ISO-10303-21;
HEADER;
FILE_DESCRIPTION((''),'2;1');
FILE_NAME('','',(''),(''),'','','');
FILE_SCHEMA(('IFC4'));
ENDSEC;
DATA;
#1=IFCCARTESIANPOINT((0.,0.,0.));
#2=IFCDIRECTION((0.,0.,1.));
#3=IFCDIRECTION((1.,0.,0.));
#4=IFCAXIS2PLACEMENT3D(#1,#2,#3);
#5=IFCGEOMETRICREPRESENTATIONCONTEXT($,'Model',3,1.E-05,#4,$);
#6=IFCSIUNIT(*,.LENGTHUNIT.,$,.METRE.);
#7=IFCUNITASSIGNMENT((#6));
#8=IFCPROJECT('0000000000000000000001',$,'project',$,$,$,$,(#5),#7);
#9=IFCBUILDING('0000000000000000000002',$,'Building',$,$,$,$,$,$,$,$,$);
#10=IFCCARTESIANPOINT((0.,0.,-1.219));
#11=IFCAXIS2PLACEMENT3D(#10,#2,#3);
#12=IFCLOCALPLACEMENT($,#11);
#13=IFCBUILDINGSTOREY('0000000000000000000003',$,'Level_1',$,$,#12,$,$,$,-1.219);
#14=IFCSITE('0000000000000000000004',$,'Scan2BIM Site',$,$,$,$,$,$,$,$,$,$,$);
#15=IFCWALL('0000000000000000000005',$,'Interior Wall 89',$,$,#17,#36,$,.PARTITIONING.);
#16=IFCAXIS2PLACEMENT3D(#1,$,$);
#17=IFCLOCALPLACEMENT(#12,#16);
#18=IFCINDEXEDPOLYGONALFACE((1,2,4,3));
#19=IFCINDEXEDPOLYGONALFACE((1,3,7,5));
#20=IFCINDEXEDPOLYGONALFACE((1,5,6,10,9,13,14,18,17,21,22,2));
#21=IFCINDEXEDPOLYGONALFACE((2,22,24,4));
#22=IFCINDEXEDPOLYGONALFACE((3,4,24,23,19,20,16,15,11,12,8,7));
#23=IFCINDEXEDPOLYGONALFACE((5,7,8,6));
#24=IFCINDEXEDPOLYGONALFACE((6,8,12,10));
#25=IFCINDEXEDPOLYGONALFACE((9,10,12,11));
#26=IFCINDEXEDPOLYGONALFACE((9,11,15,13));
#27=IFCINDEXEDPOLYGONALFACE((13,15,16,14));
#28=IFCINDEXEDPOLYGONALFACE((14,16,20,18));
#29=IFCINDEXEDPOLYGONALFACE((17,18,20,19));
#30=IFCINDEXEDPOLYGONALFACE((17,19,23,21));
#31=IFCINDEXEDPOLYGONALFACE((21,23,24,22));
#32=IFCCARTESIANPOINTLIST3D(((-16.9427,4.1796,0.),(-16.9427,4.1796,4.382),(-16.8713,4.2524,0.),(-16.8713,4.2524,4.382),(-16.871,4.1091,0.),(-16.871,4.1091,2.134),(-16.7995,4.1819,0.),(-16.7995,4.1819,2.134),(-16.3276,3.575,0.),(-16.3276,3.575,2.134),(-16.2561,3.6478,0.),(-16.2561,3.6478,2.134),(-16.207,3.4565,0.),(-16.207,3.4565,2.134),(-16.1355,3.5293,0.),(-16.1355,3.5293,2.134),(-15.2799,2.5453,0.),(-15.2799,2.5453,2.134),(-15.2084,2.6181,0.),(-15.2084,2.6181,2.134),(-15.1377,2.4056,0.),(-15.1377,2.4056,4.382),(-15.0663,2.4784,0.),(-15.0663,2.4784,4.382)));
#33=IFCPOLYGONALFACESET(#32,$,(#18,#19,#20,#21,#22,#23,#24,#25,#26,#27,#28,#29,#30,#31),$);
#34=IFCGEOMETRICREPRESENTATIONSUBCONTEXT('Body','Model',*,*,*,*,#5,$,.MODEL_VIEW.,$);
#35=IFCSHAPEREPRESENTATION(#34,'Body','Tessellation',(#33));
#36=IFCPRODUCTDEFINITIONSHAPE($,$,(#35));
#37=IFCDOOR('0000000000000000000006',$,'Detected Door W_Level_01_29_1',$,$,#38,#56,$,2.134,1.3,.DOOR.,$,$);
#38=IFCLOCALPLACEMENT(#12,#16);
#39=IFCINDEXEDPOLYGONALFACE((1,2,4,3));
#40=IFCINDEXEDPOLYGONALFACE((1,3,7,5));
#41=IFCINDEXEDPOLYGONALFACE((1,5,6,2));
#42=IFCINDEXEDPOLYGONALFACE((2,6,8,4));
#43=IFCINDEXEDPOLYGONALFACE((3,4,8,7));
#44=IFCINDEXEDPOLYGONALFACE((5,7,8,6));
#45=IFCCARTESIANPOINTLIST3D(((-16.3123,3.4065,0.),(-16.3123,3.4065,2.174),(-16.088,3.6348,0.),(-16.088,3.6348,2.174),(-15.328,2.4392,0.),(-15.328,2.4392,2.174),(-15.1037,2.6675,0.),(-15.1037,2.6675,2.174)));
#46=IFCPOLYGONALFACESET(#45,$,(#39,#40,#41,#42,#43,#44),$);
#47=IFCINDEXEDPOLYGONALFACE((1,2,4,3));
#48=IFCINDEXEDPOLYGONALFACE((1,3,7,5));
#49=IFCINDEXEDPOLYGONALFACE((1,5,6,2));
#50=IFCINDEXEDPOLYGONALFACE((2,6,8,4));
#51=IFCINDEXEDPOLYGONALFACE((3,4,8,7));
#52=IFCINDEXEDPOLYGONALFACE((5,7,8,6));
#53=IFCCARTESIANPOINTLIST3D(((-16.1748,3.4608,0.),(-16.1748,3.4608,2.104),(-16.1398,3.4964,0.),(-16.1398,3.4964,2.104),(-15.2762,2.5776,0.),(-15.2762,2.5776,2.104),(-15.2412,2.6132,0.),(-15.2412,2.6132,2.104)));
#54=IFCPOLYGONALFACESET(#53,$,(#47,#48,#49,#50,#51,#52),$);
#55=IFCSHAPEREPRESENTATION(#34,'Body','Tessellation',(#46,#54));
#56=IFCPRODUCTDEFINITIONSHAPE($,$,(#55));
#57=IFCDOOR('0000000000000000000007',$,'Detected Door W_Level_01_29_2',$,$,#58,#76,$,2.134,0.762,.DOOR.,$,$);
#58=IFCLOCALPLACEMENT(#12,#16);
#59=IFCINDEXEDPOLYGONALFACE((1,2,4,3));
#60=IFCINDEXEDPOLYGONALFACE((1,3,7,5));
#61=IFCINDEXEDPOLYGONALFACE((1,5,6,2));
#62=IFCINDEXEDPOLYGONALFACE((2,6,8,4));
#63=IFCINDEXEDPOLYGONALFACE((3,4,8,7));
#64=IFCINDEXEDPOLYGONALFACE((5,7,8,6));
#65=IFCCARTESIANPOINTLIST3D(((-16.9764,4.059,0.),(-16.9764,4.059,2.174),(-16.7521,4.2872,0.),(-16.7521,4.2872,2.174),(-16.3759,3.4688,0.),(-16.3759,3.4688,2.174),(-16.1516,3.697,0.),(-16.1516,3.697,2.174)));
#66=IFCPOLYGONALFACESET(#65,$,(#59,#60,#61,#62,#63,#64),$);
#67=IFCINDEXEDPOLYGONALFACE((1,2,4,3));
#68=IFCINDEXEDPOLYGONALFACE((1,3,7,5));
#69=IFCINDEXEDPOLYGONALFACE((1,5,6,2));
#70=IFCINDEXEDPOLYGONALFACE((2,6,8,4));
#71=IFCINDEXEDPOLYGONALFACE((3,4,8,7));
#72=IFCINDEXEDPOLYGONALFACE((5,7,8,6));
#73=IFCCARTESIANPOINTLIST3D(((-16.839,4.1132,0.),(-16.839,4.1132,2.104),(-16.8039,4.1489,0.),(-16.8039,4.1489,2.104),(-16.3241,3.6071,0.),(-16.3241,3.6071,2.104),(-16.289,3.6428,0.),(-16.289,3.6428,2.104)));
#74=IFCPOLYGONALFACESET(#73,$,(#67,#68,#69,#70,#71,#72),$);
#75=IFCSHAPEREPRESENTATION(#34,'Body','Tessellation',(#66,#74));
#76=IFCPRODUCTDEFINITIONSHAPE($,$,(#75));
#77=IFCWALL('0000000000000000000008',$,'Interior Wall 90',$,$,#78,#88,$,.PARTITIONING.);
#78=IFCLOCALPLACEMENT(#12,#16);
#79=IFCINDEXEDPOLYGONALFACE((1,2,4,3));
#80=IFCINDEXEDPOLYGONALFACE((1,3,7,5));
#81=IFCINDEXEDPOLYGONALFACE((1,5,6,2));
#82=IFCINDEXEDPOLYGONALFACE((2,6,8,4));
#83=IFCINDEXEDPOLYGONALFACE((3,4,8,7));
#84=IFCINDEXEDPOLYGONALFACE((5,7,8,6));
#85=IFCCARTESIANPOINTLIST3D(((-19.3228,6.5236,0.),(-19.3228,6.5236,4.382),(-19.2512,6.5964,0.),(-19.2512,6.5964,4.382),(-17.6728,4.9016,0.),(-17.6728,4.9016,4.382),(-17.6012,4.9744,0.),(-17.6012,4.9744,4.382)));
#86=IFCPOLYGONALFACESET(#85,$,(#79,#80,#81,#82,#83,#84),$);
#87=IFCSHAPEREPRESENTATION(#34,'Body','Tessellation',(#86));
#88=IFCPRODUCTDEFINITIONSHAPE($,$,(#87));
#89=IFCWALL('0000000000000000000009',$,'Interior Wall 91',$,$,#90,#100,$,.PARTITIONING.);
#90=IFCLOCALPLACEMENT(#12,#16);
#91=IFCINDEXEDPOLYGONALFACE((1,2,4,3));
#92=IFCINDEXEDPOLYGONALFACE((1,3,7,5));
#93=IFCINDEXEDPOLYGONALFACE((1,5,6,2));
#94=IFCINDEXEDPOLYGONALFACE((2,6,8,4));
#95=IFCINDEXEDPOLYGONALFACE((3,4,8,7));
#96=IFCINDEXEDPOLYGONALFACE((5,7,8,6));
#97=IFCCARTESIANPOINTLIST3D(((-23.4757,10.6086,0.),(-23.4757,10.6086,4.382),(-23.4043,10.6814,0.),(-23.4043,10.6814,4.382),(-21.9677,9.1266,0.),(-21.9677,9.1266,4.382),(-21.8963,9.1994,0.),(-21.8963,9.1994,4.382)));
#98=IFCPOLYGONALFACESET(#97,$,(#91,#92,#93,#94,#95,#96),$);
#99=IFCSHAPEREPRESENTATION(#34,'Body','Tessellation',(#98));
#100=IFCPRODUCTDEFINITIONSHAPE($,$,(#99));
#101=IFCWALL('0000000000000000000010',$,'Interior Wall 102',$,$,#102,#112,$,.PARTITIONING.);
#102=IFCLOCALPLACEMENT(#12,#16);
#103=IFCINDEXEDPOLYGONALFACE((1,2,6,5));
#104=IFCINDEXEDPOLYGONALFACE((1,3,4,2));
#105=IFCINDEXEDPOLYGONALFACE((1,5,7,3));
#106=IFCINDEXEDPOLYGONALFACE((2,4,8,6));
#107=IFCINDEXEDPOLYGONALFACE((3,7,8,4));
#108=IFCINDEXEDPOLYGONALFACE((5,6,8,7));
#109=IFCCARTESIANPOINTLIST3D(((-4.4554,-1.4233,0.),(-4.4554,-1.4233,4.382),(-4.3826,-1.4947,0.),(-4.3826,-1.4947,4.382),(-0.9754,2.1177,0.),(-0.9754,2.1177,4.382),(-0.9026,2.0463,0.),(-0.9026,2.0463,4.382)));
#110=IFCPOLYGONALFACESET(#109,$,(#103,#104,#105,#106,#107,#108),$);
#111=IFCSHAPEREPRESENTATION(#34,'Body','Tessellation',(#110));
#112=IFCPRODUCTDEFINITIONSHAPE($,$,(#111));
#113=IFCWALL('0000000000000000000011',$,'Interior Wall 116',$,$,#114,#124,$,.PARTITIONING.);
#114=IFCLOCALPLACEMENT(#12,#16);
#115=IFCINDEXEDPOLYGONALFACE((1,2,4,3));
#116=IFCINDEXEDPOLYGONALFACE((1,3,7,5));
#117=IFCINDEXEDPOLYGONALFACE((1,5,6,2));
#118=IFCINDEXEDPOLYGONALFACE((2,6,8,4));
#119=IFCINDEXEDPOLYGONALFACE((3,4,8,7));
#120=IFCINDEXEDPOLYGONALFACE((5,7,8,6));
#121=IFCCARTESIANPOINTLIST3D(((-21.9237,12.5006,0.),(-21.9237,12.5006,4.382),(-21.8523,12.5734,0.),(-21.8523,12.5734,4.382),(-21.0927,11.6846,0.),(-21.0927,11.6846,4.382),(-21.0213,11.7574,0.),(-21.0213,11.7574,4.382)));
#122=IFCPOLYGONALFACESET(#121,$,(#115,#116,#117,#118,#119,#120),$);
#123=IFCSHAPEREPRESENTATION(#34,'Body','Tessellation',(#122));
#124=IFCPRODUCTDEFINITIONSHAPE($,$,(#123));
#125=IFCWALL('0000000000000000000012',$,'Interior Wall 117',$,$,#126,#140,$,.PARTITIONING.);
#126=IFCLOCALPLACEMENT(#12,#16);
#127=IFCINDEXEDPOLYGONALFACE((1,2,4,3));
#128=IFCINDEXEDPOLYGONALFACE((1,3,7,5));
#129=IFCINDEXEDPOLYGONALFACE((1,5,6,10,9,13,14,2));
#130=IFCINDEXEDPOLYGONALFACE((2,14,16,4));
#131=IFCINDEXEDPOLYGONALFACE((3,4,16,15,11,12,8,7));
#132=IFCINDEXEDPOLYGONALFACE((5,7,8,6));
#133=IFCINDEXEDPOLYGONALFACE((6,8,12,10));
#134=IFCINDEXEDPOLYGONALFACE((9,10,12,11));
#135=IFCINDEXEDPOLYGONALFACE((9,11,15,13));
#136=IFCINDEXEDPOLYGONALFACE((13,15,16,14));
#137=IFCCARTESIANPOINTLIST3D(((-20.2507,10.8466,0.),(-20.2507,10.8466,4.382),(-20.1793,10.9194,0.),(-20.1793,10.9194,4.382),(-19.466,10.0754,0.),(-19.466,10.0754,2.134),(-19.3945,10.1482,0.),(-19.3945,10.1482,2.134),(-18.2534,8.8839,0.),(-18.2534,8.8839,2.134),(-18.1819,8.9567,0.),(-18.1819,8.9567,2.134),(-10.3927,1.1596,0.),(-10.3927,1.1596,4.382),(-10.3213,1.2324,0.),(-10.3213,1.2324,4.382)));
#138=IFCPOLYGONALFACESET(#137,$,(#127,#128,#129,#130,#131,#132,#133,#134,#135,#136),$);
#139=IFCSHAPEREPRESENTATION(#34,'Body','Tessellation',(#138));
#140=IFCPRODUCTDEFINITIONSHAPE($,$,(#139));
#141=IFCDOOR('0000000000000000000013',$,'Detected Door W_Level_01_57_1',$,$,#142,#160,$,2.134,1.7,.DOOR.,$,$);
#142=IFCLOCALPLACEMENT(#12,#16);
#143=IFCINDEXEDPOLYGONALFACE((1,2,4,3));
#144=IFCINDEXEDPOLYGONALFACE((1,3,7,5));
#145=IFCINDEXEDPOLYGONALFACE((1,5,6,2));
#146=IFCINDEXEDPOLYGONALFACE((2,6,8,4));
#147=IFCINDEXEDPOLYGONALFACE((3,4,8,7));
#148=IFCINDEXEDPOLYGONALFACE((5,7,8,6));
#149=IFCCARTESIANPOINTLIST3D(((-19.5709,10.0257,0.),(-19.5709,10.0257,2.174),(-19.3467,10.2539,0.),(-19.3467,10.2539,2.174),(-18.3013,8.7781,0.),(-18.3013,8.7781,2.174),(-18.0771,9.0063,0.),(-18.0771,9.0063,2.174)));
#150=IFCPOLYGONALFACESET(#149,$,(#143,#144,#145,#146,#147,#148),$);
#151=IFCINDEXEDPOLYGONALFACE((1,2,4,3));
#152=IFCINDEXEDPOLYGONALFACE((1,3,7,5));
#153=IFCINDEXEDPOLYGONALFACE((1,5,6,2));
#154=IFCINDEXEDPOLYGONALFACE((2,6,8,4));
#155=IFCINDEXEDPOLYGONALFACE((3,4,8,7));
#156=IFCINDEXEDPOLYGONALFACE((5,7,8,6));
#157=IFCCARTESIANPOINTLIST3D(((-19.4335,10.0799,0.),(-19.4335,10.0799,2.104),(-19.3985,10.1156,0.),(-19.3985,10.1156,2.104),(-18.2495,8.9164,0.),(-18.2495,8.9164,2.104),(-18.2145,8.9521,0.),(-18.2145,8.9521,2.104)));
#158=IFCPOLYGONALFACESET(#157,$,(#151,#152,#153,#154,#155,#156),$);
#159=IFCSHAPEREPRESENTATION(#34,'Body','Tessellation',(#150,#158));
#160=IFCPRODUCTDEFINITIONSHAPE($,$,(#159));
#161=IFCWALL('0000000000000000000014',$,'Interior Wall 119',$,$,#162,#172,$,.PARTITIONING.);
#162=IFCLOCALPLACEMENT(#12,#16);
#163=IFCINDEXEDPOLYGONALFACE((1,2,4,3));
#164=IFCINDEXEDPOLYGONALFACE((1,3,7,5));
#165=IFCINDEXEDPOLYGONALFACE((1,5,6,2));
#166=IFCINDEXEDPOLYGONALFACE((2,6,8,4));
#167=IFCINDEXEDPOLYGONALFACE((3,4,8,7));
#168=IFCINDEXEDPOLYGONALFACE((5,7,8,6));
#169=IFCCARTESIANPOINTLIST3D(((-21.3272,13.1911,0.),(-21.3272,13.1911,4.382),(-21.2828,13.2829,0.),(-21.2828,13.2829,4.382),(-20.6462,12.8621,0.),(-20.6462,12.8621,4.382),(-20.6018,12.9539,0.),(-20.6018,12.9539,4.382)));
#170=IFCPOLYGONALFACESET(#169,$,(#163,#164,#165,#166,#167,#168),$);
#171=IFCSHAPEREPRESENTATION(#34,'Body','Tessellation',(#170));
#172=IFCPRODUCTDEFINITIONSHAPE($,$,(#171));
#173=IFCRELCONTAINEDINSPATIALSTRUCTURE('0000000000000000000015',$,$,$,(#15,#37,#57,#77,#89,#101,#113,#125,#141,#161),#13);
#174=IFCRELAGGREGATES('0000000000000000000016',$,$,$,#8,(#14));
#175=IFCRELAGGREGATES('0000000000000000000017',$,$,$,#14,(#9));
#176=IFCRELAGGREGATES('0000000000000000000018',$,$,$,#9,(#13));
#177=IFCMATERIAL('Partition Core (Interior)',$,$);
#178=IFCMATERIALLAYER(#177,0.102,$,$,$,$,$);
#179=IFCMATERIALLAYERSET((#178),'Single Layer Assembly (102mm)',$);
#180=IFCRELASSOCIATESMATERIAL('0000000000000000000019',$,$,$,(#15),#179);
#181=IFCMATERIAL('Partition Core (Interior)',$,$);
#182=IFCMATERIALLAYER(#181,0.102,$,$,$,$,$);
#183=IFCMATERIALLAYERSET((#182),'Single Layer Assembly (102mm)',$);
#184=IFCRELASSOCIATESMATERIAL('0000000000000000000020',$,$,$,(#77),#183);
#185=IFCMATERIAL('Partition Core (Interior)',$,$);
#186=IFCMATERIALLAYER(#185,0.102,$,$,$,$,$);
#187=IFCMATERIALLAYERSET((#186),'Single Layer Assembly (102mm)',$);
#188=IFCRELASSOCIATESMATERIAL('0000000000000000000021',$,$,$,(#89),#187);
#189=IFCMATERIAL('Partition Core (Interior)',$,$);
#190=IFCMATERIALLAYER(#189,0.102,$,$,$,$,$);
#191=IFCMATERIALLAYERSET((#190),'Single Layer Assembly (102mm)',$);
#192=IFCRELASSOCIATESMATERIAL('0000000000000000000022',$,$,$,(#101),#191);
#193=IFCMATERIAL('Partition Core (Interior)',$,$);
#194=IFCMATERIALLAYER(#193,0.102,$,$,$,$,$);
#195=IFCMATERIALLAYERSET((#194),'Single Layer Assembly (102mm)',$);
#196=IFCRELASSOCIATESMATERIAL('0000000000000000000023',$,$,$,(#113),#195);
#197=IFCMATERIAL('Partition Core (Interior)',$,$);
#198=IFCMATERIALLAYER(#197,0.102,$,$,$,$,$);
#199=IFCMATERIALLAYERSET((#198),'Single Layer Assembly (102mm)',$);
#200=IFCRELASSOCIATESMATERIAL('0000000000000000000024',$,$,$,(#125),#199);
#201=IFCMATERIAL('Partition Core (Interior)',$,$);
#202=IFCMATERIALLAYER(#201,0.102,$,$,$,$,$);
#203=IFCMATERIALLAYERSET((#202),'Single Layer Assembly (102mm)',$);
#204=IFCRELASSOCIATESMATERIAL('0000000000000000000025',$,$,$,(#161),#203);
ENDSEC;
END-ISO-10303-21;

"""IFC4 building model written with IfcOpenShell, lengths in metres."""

from ifc_helpers import new_model, si_unit, frame, origin, origin_with_axes, place, context, subcontext, project, spatial, rectangle, extrude, material, layer, layer_set, element, fill, save


model = new_model("IFC4")

# Units and contexts
model_context = context("Model", 3, precision=1e-05, world=origin_with_axes())
body_context = subcontext(model_context, "Body", "Model", "MODEL_VIEW")
ifc_project = project(units=[si_unit("LENGTHUNIT", "METRE")], contexts=[model_context])

# Site, building, storey
site = spatial("IfcSite", under=ifc_project, Name="Scan2BIM Site")
building = spatial("IfcBuilding", under=site, Name="Building")
storey_placement = place(None, frame((0.0, 0.0, -1.219), z_axis=(0.0, 0.0, 1.0), x_axis=(1.0, 0.0, 0.0)))
storey = spatial("IfcBuildingStorey", under=building, at=storey_placement, Name="Level_1", Elevation=-1.219)

# Wall, openings, doors
ifc_material_1 = material(Name="Partition Core (Interior)")
ifc_layer_1 = layer(ifc_material_1, 0.102)
ifc_layer_set_1 = layer_set([ifc_layer_1], Name="Single Layer Assembly (102mm)")
wall_1_placement = place(storey_placement, frame((-16.0045, 3.329, 0.0), z_axis=(0.0, 0.0, 1.0), x_axis=(-0.713205, 0.700956, 0.0)))
wall_1 = element("IfcWall", 1, at=wall_1_placement, inside=storey, material=ifc_layer_set_1, Name="Interior Wall 89", PredefinedType="PARTITIONING", context=body_context, shape_type="SweptSolid", body=[
    extrude(rectangle(XDim=2.5308, YDim=0.102), origin(), (0.0, 0.0, 1.0), 4.382),
])
opening_1_placement = place(None, frame((-15.708, 3.037, -1.219), z_axis=(0.0, 0.0, 1.0), x_axis=(-0.713205, 0.700956, 0.0)))
opening_1 = element("IfcOpeningElement", 2, at=opening_1_placement, cuts=wall_1, PredefinedType="OPENING", context=body_context, shape_type="SweptSolid", body=[
    extrude(rectangle(XDim=1.3, YDim=0.202), origin(), (0.0, 0.0, 1.0), 2.134),
])
opening_2_placement = place(None, frame((-16.564, 3.878, -1.219), z_axis=(0.0, 0.0, 1.0), x_axis=(-0.713205, 0.700956, 0.0)))
opening_2 = element("IfcOpeningElement", 3, at=opening_2_placement, cuts=wall_1, PredefinedType="OPENING", context=body_context, shape_type="SweptSolid", body=[
    extrude(rectangle(XDim=0.762, YDim=0.202), origin(), (0.0, 0.0, 1.0), 2.134),
])
door_1_placement = place(opening_1_placement, frame((0.0, 0.0, 0.0), z_axis=(0.0, 0.0, 1.0), x_axis=(1.0, 0.0, 0.0)))
door_1 = element("IfcDoor", 4, at=door_1_placement, inside=storey, Name="Detected Door W_Level_01_29_1", OverallHeight=2.134, OverallWidth=1.3, PredefinedType="DOOR", context=body_context, shape_type="SweptSolid", body=[
    extrude(rectangle(XDim=1.38, YDim=0.32), origin(), (0.0, 0.0, 1.0), 2.174),
    extrude(rectangle(XDim=1.26, YDim=0.05), origin(), (0.0, 0.0, 1.0), 2.104),
])
fill(opening_1, door_1)
door_2_placement = place(opening_2_placement, frame((0.0, 0.0, 0.0), z_axis=(0.0, 0.0, 1.0), x_axis=(1.0, 0.0, 0.0)))
door_2 = element("IfcDoor", 5, at=door_2_placement, inside=storey, Name="Detected Door W_Level_01_29_2", OverallHeight=2.134, OverallWidth=0.762, PredefinedType="DOOR", context=body_context, shape_type="SweptSolid", body=[
    extrude(rectangle(XDim=0.842, YDim=0.32), origin(), (0.0, 0.0, 1.0), 2.174),
    extrude(rectangle(XDim=0.722, YDim=0.05), origin(), (0.0, 0.0, 1.0), 2.104),
])
fill(opening_2, door_2)

# Walls
ifc_material_2 = material(Name="Partition Core (Interior)")
ifc_layer_2 = layer(ifc_material_2, 0.102)
ifc_layer_set_2 = layer_set([ifc_layer_2], Name="Single Layer Assembly (102mm)")
wall_2_placement = place(storey_placement, frame((-18.462, 5.749, 0.0), z_axis=(0.0, 0.0, 1.0), x_axis=(-0.713132, 0.70103, 0.0)))
element("IfcWall", 6, at=wall_2_placement, inside=storey, material=ifc_layer_set_2, Name="Interior Wall 90", PredefinedType="PARTITIONING", context=body_context, shape_type="SweptSolid", body=[
    extrude(rectangle(XDim=2.3137, YDim=0.102), origin(), (0.0, 0.0, 1.0), 4.382),
])
ifc_material_3 = material(Name="Partition Core (Interior)")
ifc_layer_3 = layer(ifc_material_3, 0.102)
ifc_layer_set_3 = layer_set([ifc_layer_3], Name="Single Layer Assembly (102mm)")
wall_3_placement = place(storey_placement, frame((-22.686, 9.904, 0.0), z_axis=(0.0, 0.0, 1.0), x_axis=(-0.713229, 0.700932, 0.0)))
element("IfcWall", 7, at=wall_3_placement, inside=storey, material=ifc_layer_set_3, Name="Interior Wall 91", PredefinedType="PARTITIONING", context=body_context, shape_type="SweptSolid", body=[
    extrude(rectangle(XDim=2.1143, YDim=0.102), origin(), (0.0, 0.0, 1.0), 4.382),
])
ifc_material_4 = material(Name="Partition Core (Interior)")
ifc_layer_4 = layer(ifc_material_4, 0.102)
ifc_layer_set_4 = layer_set([ifc_layer_4], Name="Single Layer Assembly (102mm)")
wall_4_placement = place(storey_placement, frame((-2.679, 0.3115, 0.0), z_axis=(0.0, 0.0, 1.0), x_axis=(-0.700937, -0.713223, 0.0)))
element("IfcWall", 8, at=wall_4_placement, inside=storey, material=ifc_layer_set_4, Name="Interior Wall 102", PredefinedType="PARTITIONING", context=body_context, shape_type="SweptSolid", body=[
    extrude(rectangle(XDim=4.9648, YDim=0.102), origin(), (0.0, 0.0, 1.0), 4.382),
])
ifc_material_5 = material(Name="Partition Core (Interior)")
ifc_layer_5 = layer(ifc_material_5, 0.102)
ifc_layer_set_5 = layer_set([ifc_layer_5], Name="Single Layer Assembly (102mm)")
wall_5_placement = place(storey_placement, frame((-21.4725, 12.129, 0.0), z_axis=(0.0, 0.0, 1.0), x_axis=(0.713517, -0.700638, 0.0)))
element("IfcWall", 9, at=wall_5_placement, inside=storey, material=ifc_layer_set_5, Name="Interior Wall 116", PredefinedType="PARTITIONING", context=body_context, shape_type="SweptSolid", body=[
    extrude(rectangle(XDim=1.1647, YDim=0.102), origin(), (0.0, 0.0, 1.0), 4.382),
])

# Wall, opening, door
ifc_material_6 = material(Name="Partition Core (Interior)")
ifc_layer_6 = layer(ifc_material_6, 0.102)
ifc_layer_set_6 = layer_set([ifc_layer_6], Name="Single Layer Assembly (102mm)")
wall_6_placement = place(storey_placement, frame((-15.286, 6.0395, 0.0), z_axis=(0.0, 0.0, 1.0), x_axis=(0.713266, -0.700893, 0.0)))
wall_6 = element("IfcWall", 10, at=wall_6_placement, inside=storey, material=ifc_layer_set_6, Name="Interior Wall 117", PredefinedType="PARTITIONING", context=body_context, shape_type="SweptSolid", body=[
    extrude(rectangle(XDim=13.8209, YDim=0.102), origin(), (0.0, 0.0, 1.0), 4.382),
])
opening_3_placement = place(None, frame((-18.824, 9.516, -1.219), z_axis=(0.0, 0.0, 1.0), x_axis=(0.713266, -0.700893, 0.0)))
opening_3 = element("IfcOpeningElement", 11, at=opening_3_placement, cuts=wall_6, PredefinedType="OPENING", context=body_context, shape_type="SweptSolid", body=[
    extrude(rectangle(XDim=1.7, YDim=0.202), origin(), (0.0, 0.0, 1.0), 2.134),
])
door_3_placement = place(opening_3_placement, frame((0.0, 0.0, 0.0), z_axis=(0.0, 0.0, 1.0), x_axis=(1.0, 0.0, 0.0)))
door_3 = element("IfcDoor", 12, at=door_3_placement, inside=storey, Name="Detected Door W_Level_01_57_1", OverallHeight=2.134, OverallWidth=1.7, PredefinedType="DOOR", context=body_context, shape_type="SweptSolid", body=[
    extrude(rectangle(XDim=1.78, YDim=0.32), origin(), (0.0, 0.0, 1.0), 2.174),
    extrude(rectangle(XDim=1.66, YDim=0.05), origin(), (0.0, 0.0, 1.0), 2.104),
])
fill(opening_3, door_3)

# Wall
ifc_material_7 = material(Name="Partition Core (Interior)")
ifc_layer_7 = layer(ifc_material_7, 0.102)
ifc_layer_set_7 = layer_set([ifc_layer_7], Name="Single Layer Assembly (102mm)")
wall_7_placement = place(storey_placement, frame((-20.9645, 13.0725, 0.0), z_axis=(0.0, 0.0, 1.0), x_axis=(0.900427, -0.435008, 0.0)))
element("IfcWall", 13, at=wall_7_placement, inside=storey, material=ifc_layer_set_7, Name="Interior Wall 119", PredefinedType="PARTITIONING", context=body_context, shape_type="SweptSolid", body=[
    extrude(rectangle(XDim=0.7563, YDim=0.102), origin(), (0.0, 0.0, 1.0), 4.382),
])

save(model, "model.ifc")
